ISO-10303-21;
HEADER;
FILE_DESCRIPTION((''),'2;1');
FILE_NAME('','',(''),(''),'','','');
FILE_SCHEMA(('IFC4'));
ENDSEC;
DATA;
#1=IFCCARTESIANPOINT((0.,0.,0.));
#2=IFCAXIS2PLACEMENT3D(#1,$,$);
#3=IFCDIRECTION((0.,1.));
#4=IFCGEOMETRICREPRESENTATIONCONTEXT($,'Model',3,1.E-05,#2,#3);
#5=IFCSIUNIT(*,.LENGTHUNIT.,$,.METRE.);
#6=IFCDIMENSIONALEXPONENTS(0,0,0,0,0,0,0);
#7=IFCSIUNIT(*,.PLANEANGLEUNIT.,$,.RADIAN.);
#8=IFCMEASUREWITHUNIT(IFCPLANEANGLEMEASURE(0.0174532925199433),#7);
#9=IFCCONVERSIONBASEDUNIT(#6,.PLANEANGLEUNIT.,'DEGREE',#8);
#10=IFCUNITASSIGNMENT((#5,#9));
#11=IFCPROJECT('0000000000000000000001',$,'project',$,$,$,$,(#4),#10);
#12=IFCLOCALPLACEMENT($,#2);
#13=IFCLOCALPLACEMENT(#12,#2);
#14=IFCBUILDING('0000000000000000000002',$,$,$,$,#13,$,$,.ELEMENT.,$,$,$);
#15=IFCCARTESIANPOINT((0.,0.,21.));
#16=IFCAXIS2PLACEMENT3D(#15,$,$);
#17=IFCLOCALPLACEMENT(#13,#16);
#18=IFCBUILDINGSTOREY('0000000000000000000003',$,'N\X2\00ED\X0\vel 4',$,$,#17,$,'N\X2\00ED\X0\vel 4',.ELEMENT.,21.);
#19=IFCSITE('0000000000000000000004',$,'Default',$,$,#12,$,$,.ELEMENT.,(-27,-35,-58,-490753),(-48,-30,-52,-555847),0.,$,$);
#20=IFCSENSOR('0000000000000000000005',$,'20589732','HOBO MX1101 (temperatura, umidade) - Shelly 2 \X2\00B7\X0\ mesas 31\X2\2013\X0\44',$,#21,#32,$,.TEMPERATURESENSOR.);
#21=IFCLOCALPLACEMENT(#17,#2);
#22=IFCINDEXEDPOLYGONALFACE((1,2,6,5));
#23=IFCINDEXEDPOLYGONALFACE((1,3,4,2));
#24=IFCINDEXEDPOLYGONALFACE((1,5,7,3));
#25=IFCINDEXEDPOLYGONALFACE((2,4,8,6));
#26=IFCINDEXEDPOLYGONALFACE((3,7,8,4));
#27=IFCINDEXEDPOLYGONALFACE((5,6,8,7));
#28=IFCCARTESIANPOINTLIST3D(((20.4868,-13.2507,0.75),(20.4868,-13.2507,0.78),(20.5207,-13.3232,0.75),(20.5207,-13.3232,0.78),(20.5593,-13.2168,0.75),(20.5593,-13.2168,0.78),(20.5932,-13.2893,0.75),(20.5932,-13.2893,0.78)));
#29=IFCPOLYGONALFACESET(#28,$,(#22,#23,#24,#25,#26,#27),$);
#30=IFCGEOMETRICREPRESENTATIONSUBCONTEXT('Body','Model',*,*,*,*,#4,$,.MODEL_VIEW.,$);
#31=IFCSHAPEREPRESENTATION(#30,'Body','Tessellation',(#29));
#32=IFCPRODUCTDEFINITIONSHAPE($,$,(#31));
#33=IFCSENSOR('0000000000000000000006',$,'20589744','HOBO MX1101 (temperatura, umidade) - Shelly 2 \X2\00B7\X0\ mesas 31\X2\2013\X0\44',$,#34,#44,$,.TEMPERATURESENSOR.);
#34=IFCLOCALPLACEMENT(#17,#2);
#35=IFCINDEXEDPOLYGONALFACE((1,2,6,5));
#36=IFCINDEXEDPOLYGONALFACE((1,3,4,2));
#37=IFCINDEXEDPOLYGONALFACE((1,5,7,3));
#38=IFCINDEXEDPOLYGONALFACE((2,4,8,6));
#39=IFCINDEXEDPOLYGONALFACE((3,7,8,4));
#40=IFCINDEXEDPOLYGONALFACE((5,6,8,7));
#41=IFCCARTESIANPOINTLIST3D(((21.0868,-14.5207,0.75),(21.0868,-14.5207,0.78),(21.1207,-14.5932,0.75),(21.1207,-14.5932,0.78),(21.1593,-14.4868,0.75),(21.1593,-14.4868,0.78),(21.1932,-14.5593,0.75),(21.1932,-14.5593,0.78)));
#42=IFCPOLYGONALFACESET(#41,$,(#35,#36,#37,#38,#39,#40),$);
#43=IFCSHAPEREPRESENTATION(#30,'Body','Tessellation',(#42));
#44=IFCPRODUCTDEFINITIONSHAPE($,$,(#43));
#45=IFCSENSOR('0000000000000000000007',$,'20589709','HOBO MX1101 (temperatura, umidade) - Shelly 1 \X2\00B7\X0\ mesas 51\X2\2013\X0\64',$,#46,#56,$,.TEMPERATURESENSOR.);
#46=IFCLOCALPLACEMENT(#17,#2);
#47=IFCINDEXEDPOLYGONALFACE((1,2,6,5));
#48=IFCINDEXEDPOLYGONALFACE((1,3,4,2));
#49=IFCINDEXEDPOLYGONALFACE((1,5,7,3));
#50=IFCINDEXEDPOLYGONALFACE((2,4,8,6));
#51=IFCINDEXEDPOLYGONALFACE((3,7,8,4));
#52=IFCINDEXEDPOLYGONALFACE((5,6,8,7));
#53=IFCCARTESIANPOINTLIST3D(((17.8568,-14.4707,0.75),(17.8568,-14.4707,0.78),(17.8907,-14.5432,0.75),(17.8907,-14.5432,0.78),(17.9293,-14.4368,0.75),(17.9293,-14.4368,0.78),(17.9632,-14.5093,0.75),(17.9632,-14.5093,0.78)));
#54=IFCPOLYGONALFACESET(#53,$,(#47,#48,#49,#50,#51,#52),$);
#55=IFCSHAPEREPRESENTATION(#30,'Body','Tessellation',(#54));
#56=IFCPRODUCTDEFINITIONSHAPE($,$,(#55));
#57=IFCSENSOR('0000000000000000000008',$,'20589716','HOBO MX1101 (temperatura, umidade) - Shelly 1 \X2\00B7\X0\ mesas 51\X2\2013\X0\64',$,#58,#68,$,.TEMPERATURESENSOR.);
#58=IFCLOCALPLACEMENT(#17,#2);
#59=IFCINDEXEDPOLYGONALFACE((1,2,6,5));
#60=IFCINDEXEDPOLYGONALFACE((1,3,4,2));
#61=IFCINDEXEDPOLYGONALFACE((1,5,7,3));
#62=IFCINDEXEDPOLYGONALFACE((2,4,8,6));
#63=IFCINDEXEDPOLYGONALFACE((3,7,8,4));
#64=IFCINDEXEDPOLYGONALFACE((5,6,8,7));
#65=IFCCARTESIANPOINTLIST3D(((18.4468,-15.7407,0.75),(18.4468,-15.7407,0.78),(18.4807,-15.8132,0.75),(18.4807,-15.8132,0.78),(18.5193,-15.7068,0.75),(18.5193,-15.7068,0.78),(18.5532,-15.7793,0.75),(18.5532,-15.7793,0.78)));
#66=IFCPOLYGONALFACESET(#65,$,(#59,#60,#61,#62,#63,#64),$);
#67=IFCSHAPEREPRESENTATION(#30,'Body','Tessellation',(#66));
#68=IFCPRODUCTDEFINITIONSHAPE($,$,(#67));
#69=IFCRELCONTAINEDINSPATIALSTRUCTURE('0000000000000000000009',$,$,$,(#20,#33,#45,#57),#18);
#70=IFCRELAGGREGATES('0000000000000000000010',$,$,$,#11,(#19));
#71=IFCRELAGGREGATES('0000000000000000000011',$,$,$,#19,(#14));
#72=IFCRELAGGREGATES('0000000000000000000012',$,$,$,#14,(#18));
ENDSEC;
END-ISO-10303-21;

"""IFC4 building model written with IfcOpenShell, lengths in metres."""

from ifc_helpers import new_model, entity, si_unit, converted_unit, direction, frame, origin, origin_2d, place, context, subcontext, project, spatial, rectangle, extrude, element, save


model = new_model("IFC4")

# Units and contexts
model_context = context("Model", 3, precision=1e-05, world=origin(), true_north=direction((0.0, 1.0)))
body_context = subcontext(model_context, "Body", "Model", "MODEL_VIEW")
ifc_project = project(units=[si_unit("LENGTHUNIT", "METRE"), converted_unit("PLANEANGLEUNIT", "DEGREE", entity("IfcPlaneAngleMeasure", 0.0174532925199433), si_unit("PLANEANGLEUNIT", "RADIAN"), dimensions=[0, 0, 0, 0, 0, 0, 0])], contexts=[model_context])

# Site, building, storey
site_placement = place(None, origin())
site = spatial("IfcSite", under=ifc_project, at=site_placement, Name="Default", CompositionType="ELEMENT", RefLatitude=(-27, -35, -58, -490753), RefLongitude=(-48, -30, -52, -555847), RefElevation=0.0)
building_placement = place(site_placement, origin())
building = spatial("IfcBuilding", under=site, at=building_placement, CompositionType="ELEMENT")
storey_placement = place(building_placement, frame((0.0, 0.0, 21.0)))
storey = spatial("IfcBuildingStorey", under=building, at=storey_placement, Name="Nível 4", LongName="Nível 4", CompositionType="ELEMENT", Elevation=21.0)

# Sensors
for number, where, z_axis, x_axis, name, description in (
    (1, (20.54, -13.27, 21.75), (0.0, 0.0, 1.0), (0.906245, 0.422754, 0.0), "20589732", "HOBO MX1101 (temperatura, umidade) - Shelly 2 · mesas 31–44"),
    (2, (21.14, -14.54, 21.75), (0.0, 0.0, 1.0), (0.906245, 0.422754, 0.0), "20589744", "HOBO MX1101 (temperatura, umidade) - Shelly 2 · mesas 31–44"),
    (3, (17.91, -14.49, 21.75), (0.0, 0.0, 1.0), (0.906245, 0.422754, 0.0), "20589709", "HOBO MX1101 (temperatura, umidade) - Shelly 1 · mesas 51–64"),
    (4, (18.5, -15.76, 21.75), (0.0, 0.0, 1.0), (0.906245, 0.422754, 0.0), "20589716", "HOBO MX1101 (temperatura, umidade) - Shelly 1 · mesas 51–64"),
):
    element("IfcSensor", number, at=place(None, frame(where, z_axis=z_axis, x_axis=x_axis)), inside=storey, Name=name, Description=description, PredefinedType="TEMPERATURESENSOR", context=body_context, shape_type="SweptSolid", body=[
        extrude(rectangle(XDim=0.08, YDim=0.08, at=origin_2d()), None, (0.0, 0.0, 1.0), 0.03),
    ])

save(model, "model.ifc")
